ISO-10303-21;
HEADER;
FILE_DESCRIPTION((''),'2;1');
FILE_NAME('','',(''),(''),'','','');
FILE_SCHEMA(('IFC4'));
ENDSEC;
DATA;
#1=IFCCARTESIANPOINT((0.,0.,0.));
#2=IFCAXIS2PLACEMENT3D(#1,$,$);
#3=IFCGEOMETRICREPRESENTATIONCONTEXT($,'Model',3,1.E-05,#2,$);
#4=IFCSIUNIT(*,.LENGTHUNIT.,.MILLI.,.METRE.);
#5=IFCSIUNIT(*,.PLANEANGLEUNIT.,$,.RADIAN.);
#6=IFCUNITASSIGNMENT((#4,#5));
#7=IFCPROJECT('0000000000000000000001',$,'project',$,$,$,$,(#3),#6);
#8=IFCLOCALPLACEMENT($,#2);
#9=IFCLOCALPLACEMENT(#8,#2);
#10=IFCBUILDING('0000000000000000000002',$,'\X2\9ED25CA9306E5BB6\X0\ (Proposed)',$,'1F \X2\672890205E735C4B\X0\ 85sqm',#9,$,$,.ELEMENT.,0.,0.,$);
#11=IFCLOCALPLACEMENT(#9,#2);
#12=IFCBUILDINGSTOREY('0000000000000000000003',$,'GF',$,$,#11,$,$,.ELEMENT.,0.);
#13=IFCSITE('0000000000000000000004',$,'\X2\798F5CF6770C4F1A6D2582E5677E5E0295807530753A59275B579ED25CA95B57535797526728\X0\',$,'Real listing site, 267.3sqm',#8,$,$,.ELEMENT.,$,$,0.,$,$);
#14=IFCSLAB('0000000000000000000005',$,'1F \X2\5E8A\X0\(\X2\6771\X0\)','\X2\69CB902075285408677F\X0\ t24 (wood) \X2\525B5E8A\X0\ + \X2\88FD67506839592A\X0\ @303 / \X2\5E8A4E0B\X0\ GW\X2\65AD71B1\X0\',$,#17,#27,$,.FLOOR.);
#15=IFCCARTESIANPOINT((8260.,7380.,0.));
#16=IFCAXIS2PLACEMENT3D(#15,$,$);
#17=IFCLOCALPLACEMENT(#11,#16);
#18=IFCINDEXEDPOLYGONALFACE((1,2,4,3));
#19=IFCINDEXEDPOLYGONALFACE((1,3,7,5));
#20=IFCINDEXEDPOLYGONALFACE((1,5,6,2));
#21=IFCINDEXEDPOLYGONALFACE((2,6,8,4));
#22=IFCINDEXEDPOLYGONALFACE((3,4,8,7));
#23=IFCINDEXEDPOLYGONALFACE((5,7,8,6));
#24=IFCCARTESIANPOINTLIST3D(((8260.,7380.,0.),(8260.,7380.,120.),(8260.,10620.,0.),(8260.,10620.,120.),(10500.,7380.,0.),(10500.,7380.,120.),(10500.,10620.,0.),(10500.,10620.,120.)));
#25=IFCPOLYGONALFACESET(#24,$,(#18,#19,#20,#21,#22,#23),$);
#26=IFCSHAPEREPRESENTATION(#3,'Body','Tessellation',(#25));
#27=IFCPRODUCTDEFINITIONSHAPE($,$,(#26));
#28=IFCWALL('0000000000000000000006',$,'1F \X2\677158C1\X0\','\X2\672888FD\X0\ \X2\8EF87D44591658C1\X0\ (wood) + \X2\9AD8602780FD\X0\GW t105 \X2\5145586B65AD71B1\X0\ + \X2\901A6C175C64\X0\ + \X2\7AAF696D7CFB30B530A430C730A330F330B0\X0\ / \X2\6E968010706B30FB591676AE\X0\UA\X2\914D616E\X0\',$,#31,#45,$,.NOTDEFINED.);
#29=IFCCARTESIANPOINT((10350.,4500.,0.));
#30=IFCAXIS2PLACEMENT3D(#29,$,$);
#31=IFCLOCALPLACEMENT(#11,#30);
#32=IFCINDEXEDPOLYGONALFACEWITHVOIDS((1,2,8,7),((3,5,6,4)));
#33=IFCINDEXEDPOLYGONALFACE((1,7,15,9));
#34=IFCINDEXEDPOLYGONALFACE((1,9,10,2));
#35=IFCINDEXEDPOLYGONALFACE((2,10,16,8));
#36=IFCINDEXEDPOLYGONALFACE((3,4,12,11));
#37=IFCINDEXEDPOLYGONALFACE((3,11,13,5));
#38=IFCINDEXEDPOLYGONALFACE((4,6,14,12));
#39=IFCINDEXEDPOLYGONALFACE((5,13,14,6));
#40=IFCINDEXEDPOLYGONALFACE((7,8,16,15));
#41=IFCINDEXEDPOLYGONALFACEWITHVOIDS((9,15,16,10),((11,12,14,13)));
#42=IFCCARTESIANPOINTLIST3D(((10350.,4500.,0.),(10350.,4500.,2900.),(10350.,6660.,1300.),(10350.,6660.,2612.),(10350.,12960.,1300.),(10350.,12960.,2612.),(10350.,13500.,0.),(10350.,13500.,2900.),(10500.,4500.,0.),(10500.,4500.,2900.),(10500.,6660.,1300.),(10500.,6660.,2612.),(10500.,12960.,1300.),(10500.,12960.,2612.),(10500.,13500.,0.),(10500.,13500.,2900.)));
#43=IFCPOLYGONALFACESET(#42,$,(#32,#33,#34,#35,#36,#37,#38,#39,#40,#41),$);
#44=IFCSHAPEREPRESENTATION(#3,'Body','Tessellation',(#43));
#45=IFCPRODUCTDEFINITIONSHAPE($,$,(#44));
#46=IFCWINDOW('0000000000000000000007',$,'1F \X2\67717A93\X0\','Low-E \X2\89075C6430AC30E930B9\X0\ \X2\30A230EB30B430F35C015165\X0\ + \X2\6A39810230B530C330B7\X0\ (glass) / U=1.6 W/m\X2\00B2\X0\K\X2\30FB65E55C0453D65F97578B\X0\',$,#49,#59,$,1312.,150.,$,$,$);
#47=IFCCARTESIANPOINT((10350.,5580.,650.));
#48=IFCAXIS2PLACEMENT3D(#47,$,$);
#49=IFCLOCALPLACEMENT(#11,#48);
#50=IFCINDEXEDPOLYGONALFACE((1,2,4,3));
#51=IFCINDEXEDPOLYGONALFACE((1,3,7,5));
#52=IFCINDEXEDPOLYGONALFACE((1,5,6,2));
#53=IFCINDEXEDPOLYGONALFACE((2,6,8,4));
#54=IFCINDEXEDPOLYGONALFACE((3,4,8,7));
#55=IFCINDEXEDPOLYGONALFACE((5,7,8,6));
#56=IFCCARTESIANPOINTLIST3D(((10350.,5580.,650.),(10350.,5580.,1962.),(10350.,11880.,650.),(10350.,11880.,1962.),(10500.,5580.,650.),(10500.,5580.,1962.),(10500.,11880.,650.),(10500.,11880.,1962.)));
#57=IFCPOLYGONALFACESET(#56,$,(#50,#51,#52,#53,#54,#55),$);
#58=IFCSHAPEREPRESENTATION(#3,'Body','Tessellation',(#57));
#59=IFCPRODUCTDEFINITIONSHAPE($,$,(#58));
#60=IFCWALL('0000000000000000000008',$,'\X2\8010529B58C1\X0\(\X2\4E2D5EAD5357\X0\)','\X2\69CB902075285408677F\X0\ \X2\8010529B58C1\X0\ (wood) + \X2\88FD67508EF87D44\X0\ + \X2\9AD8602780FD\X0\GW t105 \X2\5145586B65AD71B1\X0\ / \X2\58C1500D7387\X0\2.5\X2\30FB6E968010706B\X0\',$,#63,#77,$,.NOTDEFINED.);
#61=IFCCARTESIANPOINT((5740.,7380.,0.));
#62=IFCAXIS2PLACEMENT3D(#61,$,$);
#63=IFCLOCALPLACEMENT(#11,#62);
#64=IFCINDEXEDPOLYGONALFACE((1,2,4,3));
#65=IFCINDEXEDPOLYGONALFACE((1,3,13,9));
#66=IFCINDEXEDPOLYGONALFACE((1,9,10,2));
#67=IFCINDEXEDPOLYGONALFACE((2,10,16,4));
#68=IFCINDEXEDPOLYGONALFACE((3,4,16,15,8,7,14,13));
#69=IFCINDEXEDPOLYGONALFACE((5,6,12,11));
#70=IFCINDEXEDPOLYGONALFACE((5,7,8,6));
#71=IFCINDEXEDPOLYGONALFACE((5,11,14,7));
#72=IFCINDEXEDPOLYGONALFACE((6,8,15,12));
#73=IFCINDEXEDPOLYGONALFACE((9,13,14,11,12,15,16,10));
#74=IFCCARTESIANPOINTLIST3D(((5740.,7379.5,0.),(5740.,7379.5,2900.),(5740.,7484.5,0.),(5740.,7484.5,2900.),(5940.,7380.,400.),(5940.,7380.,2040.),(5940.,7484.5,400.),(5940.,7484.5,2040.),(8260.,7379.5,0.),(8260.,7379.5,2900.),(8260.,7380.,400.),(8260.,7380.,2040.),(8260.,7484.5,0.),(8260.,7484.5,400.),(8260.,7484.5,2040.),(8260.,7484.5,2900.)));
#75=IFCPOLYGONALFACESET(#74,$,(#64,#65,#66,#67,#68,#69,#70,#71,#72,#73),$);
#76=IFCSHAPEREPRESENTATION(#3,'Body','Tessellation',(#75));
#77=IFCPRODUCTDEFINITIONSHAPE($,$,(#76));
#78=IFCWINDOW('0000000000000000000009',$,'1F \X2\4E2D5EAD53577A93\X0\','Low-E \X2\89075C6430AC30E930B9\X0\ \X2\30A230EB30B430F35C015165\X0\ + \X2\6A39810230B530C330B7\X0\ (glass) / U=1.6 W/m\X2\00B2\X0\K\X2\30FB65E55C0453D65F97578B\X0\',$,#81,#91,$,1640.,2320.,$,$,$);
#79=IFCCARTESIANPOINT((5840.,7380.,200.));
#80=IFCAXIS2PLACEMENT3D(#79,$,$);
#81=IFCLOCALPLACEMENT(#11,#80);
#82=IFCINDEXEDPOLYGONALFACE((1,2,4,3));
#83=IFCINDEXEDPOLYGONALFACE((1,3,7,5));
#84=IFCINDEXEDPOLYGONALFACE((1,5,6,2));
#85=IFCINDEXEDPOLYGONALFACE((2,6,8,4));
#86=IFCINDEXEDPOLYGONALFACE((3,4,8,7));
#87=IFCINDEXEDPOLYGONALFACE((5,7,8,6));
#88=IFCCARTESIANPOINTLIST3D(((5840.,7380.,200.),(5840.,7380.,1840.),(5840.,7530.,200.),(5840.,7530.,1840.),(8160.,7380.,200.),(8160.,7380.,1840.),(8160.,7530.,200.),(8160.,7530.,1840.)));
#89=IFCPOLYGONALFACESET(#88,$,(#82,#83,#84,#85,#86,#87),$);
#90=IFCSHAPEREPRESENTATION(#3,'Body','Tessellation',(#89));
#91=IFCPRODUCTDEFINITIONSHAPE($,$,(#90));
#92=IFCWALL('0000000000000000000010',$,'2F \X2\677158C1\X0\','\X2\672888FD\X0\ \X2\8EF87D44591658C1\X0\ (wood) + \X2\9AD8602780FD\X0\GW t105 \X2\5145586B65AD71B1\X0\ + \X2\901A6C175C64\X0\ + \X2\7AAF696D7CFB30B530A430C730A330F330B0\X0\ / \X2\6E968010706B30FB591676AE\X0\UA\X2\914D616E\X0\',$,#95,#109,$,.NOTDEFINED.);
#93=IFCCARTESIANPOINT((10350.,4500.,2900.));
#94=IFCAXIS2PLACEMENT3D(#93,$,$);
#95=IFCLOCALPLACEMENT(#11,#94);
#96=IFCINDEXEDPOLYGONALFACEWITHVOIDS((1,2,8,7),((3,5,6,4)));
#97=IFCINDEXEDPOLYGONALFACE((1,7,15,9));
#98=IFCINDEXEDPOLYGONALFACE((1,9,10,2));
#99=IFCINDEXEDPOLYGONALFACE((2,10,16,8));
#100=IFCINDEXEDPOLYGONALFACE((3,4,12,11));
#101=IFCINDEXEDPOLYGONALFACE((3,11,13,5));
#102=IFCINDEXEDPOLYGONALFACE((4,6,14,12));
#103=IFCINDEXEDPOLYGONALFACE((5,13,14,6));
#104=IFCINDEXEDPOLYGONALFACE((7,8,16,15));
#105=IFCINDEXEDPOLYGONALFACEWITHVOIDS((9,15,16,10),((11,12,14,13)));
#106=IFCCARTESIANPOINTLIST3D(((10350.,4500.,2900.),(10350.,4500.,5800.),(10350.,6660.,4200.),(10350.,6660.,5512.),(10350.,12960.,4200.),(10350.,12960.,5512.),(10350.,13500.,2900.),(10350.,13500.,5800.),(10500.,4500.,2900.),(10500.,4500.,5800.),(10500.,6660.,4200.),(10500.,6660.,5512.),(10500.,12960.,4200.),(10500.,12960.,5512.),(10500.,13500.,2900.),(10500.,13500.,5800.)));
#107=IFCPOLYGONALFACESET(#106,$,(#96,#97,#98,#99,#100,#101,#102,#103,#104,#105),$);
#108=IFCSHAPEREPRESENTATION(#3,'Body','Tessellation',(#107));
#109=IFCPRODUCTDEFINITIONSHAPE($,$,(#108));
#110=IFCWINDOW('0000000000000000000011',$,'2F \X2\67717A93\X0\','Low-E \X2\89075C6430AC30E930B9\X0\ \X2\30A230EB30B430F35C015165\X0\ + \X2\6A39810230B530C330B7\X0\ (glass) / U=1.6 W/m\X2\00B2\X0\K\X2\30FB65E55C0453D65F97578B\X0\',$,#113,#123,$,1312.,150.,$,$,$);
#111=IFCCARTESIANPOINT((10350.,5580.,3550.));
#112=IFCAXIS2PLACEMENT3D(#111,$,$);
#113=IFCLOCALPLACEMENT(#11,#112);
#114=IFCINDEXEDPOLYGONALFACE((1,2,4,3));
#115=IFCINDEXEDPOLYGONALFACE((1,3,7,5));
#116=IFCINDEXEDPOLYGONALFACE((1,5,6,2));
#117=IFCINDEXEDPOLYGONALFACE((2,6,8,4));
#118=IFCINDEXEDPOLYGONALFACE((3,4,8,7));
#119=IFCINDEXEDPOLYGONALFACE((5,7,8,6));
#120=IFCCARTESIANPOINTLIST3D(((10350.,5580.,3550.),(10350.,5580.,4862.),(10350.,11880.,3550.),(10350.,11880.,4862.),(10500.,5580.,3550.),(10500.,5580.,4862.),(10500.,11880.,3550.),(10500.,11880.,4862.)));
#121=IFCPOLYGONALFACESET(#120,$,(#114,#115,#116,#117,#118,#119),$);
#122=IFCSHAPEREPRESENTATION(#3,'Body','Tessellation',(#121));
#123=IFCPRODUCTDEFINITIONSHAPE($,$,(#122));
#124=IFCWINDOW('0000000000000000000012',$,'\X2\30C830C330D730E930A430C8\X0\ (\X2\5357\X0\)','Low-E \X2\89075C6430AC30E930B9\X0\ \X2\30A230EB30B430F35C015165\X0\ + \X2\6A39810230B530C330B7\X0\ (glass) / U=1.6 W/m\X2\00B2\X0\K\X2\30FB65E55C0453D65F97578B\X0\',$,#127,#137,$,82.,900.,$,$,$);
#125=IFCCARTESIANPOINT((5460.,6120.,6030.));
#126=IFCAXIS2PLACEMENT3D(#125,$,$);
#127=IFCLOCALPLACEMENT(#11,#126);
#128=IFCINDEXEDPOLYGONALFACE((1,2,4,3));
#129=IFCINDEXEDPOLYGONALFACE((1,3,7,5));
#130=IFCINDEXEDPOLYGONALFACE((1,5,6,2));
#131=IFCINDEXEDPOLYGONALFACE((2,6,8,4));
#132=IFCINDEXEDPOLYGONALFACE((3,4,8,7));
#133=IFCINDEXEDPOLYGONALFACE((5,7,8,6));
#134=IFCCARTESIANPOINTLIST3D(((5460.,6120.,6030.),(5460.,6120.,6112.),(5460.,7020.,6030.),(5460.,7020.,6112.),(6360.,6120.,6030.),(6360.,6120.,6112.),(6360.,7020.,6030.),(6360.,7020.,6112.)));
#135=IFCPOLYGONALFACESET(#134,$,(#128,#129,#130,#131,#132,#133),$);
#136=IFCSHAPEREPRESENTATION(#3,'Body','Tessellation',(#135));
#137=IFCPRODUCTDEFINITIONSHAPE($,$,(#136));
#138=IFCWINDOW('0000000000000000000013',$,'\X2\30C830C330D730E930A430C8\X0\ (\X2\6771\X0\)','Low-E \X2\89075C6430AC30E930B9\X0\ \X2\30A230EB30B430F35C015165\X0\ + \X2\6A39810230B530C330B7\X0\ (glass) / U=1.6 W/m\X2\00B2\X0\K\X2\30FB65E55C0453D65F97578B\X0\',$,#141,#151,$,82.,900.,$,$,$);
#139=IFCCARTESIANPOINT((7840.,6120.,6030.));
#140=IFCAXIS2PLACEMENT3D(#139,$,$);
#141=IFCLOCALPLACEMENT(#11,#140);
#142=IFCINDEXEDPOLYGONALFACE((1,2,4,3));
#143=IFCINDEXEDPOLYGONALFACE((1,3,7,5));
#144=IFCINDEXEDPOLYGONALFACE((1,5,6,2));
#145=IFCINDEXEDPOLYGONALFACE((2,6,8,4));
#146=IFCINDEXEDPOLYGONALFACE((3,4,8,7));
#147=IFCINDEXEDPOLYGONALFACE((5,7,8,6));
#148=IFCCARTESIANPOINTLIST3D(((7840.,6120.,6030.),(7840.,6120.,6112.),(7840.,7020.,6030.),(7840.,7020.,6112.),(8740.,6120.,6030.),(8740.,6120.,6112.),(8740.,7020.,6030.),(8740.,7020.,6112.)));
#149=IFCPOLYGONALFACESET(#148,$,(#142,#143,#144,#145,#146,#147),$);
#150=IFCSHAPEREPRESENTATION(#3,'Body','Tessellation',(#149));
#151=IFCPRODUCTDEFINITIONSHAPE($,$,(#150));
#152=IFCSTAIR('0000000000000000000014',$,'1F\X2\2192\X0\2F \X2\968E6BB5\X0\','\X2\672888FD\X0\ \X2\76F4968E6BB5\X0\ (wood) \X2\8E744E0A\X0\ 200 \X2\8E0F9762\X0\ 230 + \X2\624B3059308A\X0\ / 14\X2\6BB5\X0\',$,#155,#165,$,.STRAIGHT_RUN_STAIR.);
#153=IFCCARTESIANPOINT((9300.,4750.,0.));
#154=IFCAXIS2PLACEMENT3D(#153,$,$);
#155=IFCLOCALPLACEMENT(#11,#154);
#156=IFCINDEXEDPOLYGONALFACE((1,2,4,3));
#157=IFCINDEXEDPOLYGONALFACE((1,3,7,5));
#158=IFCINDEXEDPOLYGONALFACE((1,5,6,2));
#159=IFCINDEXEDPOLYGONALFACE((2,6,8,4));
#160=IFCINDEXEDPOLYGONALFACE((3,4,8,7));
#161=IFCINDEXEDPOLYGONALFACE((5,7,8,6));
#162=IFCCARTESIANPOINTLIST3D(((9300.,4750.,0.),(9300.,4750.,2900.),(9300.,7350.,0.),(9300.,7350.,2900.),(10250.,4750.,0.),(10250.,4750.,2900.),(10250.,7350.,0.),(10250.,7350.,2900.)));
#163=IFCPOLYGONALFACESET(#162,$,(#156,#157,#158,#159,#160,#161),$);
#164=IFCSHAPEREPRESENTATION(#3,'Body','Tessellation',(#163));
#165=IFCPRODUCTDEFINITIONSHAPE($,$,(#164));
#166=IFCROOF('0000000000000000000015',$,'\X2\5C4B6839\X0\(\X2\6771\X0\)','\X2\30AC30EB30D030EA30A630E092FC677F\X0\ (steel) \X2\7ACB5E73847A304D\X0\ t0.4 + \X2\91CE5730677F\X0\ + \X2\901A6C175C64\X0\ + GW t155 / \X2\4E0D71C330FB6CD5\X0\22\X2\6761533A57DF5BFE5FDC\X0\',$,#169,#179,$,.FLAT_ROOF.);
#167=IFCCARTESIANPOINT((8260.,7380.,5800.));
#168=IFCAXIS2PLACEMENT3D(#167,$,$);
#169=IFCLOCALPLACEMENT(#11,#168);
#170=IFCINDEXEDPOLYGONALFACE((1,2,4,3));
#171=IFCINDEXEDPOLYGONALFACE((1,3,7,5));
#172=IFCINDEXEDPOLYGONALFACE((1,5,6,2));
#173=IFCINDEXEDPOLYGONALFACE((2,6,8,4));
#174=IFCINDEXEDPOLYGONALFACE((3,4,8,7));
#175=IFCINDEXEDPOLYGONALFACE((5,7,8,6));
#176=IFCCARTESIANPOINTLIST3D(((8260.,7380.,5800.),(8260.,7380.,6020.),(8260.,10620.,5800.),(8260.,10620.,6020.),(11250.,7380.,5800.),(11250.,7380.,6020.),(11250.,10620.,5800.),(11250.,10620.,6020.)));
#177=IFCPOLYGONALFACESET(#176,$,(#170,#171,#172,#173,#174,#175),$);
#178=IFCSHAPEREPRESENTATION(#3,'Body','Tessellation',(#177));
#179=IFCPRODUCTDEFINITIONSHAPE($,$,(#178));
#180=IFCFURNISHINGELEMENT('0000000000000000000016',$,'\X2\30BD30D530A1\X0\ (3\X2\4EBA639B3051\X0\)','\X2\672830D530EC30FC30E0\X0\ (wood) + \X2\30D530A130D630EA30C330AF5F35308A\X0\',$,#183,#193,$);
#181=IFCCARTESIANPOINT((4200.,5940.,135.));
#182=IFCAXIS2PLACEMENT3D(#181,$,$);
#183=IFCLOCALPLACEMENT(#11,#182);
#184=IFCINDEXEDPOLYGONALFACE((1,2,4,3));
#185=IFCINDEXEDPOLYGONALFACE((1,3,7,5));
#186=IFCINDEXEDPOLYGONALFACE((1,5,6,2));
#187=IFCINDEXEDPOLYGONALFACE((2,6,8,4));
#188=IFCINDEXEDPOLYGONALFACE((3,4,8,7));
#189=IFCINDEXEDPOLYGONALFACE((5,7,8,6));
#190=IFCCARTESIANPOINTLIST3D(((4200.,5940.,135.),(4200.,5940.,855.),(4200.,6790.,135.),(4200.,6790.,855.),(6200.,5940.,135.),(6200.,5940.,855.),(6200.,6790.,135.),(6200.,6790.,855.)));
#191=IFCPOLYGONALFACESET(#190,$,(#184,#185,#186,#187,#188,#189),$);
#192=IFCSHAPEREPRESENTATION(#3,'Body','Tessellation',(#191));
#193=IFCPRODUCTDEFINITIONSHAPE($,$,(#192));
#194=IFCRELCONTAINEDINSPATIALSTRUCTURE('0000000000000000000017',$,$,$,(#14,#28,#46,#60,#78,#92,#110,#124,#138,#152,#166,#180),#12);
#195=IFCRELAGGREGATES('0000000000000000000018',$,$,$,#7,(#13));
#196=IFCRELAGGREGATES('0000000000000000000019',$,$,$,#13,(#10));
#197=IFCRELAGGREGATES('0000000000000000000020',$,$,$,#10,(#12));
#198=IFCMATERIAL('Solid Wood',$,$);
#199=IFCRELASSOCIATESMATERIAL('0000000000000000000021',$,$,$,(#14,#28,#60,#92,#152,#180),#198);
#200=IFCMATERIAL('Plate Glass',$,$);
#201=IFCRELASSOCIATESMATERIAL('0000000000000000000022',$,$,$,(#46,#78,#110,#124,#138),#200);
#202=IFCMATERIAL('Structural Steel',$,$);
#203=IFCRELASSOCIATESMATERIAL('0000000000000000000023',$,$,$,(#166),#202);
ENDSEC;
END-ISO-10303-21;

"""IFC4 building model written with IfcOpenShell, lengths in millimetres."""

from ifc_helpers import new_model, si_unit, frame, frame_2d, origin, place, context, project, spatial, rectangle, extrude, material, element, fill, save


model = new_model("IFC4")

# Units and contexts
model_context = context("Model", 3, precision=1e-05, world=origin())
ifc_project = project(units=[si_unit("LENGTHUNIT", "METRE", prefix="MILLI"), si_unit("PLANEANGLEUNIT", "RADIAN")], contexts=[model_context])

# Site, building, storey
site_placement = place(None, origin())
site = spatial("IfcSite", under=ifc_project, at=site_placement, Name="福島県会津若松市門田町大字黒岩字南青木", ObjectType="Real listing site, 267.3sqm", CompositionType="ELEMENT", RefElevation=0.0)
building_placement = place(site_placement, origin())
building = spatial("IfcBuilding", under=site, at=building_placement, Name="黒岩の家 (Proposed)", ObjectType="1F 木造平屋 85sqm", CompositionType="ELEMENT", ElevationOfRefHeight=0.0, ElevationOfTerrain=0.0)
storey_placement = place(building_placement, origin())
storey = spatial("IfcBuildingStorey", under=building, at=storey_placement, Name="GF", CompositionType="ELEMENT", Elevation=0.0)

# Slab
ifc_material_1 = material(Name="Solid Wood")
slab_placement = place(storey_placement, frame((8260.0, 7380.0, 0.0)))
element("IfcSlab", 1, at=slab_placement, inside=storey, material=ifc_material_1, Name="1F 床(東)", Description="構造用合板 t24 (wood) 剛床 + 製材根太 @303 / 床下 GW断熱", PredefinedType="FLOOR", context=model_context, shape_type="SweptSolid", body=[
    extrude(rectangle(XDim=2240.0, YDim=3240.0, at=frame_2d((1120.0, 1620.0))), frame((8260.0, 7380.0, 0.0)), (0.0, 0.0, 1.0), 120.0),
])

# Walls, openings, windows
wall_1_placement = place(storey_placement, frame((10350.0, 4500.0, 0.0)))
wall_1 = element("IfcWall", 2, at=wall_1_placement, inside=storey, material=ifc_material_1, Name="1F 東壁", Description="木製 軸組外壁 (wood) + 高性能GW t105 充填断熱 + 通気層 + 窯業系サイディング / 準耐火・外皮UA配慮", PredefinedType="NOTDEFINED", context=model_context, shape_type="SweptSolid", body=[
    extrude(rectangle(XDim=150.0, YDim=9000.0, at=frame_2d((75.0, 4500.0))), frame((10350.0, 4500.0, 0.0)), (0.0, 0.0, 1.0), 2900.0),
])
opening_1_placement = place(storey_placement, frame((10350.0, 5580.0, 650.0)))
opening_1 = element("IfcOpeningElement", 3, at=opening_1_placement, cuts=wall_1, PredefinedType="NOTDEFINED", context=model_context, shape_type="SweptSolid", body=[
    extrude(rectangle(XDim=150.0, YDim=6300.0, at=frame_2d((75.0, 3150.0))), frame((10350.0, 5580.0, 650.0)), (0.0, 0.0, 1.0), 1312.0),
])
ifc_material_2 = material(Name="Plate Glass")
window_1_placement = place(storey_placement, frame((10350.0, 5580.0, 650.0)))
window_1 = element("IfcWindow", 4, at=window_1_placement, inside=storey, material=ifc_material_2, Name="1F 東窓", Description="Low-E 複層ガラス アルゴン封入 + 樹脂サッシ (glass) / U=1.6 W/m²K・日射取得型", OverallHeight=1312.0, OverallWidth=150.0, context=model_context, shape_type="SweptSolid", body=[
    extrude(rectangle(XDim=150.0, YDim=6300.0, at=frame_2d((75.0, 3150.0))), frame((10350.0, 5580.0, 650.0)), (0.0, 0.0, 1.0), 1312.0),
])
fill(opening_1, window_1)
wall_2_placement = place(storey_placement, frame((5740.0, 7380.0, 0.0)))
wall_2 = element("IfcWall", 5, at=wall_2_placement, inside=storey, material=ifc_material_1, Name="耐力壁(中庭南)", Description="構造用合板 耐力壁 (wood) + 製材軸組 + 高性能GW t105 充填断熱 / 壁倍率2.5・準耐火", PredefinedType="NOTDEFINED", context=model_context, shape_type="SweptSolid", body=[
    extrude(rectangle(XDim=2520.0, YDim=105.0, at=frame_2d((1260.0, 52.0))), frame((5740.0, 7380.0, 0.0)), (0.0, 0.0, 1.0), 2900.0),
])
opening_2_placement = place(storey_placement, frame((5840.0, 7380.0, 200.0)))
opening_2 = element("IfcOpeningElement", 6, at=opening_2_placement, cuts=wall_2, PredefinedType="NOTDEFINED", context=model_context, shape_type="SweptSolid", body=[
    extrude(rectangle(XDim=2320.0, YDim=150.0, at=frame_2d((1160.0, 75.0))), frame((5840.0, 7380.0, 200.0)), (0.0, 0.0, 1.0), 1640.0),
])
window_2_placement = place(storey_placement, frame((5840.0, 7380.0, 200.0)))
window_2 = element("IfcWindow", 7, at=window_2_placement, inside=storey, material=ifc_material_2, Name="1F 中庭南窓", Description="Low-E 複層ガラス アルゴン封入 + 樹脂サッシ (glass) / U=1.6 W/m²K・日射取得型", OverallHeight=1640.0, OverallWidth=2320.0, context=model_context, shape_type="SweptSolid", body=[
    extrude(rectangle(XDim=2320.0, YDim=150.0, at=frame_2d((1160.0, 75.0))), frame((5840.0, 7380.0, 200.0)), (0.0, 0.0, 1.0), 1640.0),
])
fill(opening_2, window_2)

# Wall, opening, window
wall_3_placement = place(storey_placement, frame((10350.0, 4500.0, 2900.0)))
wall_3 = element("IfcWall", 8, at=wall_3_placement, inside=storey, material=ifc_material_1, Name="2F 東壁", Description="木製 軸組外壁 (wood) + 高性能GW t105 充填断熱 + 通気層 + 窯業系サイディング / 準耐火・外皮UA配慮", PredefinedType="NOTDEFINED", context=model_context, shape_type="SweptSolid", body=[
    extrude(rectangle(XDim=150.0, YDim=9000.0, at=frame_2d((75.0, 4500.0))), frame((10350.0, 4500.0, 2900.0)), (0.0, 0.0, 1.0), 2900.0),
])
opening_3_placement = place(storey_placement, frame((10350.0, 5580.0, 3550.0)))
opening_3 = element("IfcOpeningElement", 9, at=opening_3_placement, cuts=wall_3, PredefinedType="NOTDEFINED", context=model_context, shape_type="SweptSolid", body=[
    extrude(rectangle(XDim=150.0, YDim=6300.0, at=frame_2d((75.0, 3150.0))), frame((10350.0, 5580.0, 3550.0)), (0.0, 0.0, 1.0), 1312.0),
])
window_3_placement = place(storey_placement, frame((10350.0, 5580.0, 3550.0)))
window_3 = element("IfcWindow", 10, at=window_3_placement, inside=storey, material=ifc_material_2, Name="2F 東窓", Description="Low-E 複層ガラス アルゴン封入 + 樹脂サッシ (glass) / U=1.6 W/m²K・日射取得型", OverallHeight=1312.0, OverallWidth=150.0, context=model_context, shape_type="SweptSolid", body=[
    extrude(rectangle(XDim=150.0, YDim=6300.0, at=frame_2d((75.0, 3150.0))), frame((10350.0, 5580.0, 3550.0)), (0.0, 0.0, 1.0), 1312.0),
])
fill(opening_3, window_3)

# Windows
window_4_placement = place(storey_placement, frame((5460.0, 6120.0, 6030.0)))
element("IfcWindow", 11, at=window_4_placement, inside=storey, material=ifc_material_2, Name="トップライト (南)", Description="Low-E 複層ガラス アルゴン封入 + 樹脂サッシ (glass) / U=1.6 W/m²K・日射取得型", OverallHeight=82.0, OverallWidth=900.0, context=model_context, shape_type="SweptSolid", body=[
    extrude(rectangle(XDim=900.0, YDim=900.0, at=frame_2d((450.0, 450.0))), frame((5460.0, 6120.0, 6030.0)), (0.0, 0.0, 1.0), 82.0),
])
window_5_placement = place(storey_placement, frame((7840.0, 6120.0, 6030.0)))
element("IfcWindow", 12, at=window_5_placement, inside=storey, material=ifc_material_2, Name="トップライト (東)", Description="Low-E 複層ガラス アルゴン封入 + 樹脂サッシ (glass) / U=1.6 W/m²K・日射取得型", OverallHeight=82.0, OverallWidth=900.0, context=model_context, shape_type="SweptSolid", body=[
    extrude(rectangle(XDim=900.0, YDim=900.0, at=frame_2d((450.0, 450.0))), frame((7840.0, 6120.0, 6030.0)), (0.0, 0.0, 1.0), 82.0),
])

# Stair
stair_placement = place(storey_placement, frame((9300.0, 4750.0, 0.0)))
element("IfcStair", 13, at=stair_placement, inside=storey, material=ifc_material_1, Name="1F→2F 階段", Description="木製 直階段 (wood) 蹴上 200 踏面 230 + 手すり / 14段", PredefinedType="STRAIGHT_RUN_STAIR", context=model_context, shape_type="SweptSolid", body=[
    extrude(rectangle(XDim=950.0, YDim=2600.0, at=frame_2d((475.0, 1300.0))), frame((9300.0, 4750.0, 0.0)), (0.0, 0.0, 1.0), 2900.0),
])

# Roof
ifc_material_3 = material(Name="Structural Steel")
roof_placement = place(storey_placement, frame((8260.0, 7380.0, 5800.0)))
element("IfcRoof", 14, at=roof_placement, inside=storey, material=ifc_material_3, Name="屋根(東)", Description="ガルバリウム鋼板 (steel) 立平葺き t0.4 + 野地板 + 通気層 + GW t155 / 不燃・法22条区域対応", PredefinedType="FLAT_ROOF", context=model_context, shape_type="SweptSolid", body=[
    extrude(rectangle(XDim=2990.0, YDim=3240.0, at=frame_2d((1495.0, 1620.0))), frame((8260.0, 7380.0, 5800.0)), (0.0, 0.0, 1.0), 220.0),
])

# Furnishing element
furnishing_1_placement = place(storey_placement, frame((4200.0, 5940.0, 135.0)))
element("IfcFurnishingElement", 15, at=furnishing_1_placement, inside=storey, material=ifc_material_1, Name="ソファ (3人掛け)", Description="木フレーム (wood) + ファブリック張り", context=model_context, shape_type="SweptSolid", body=[
    extrude(rectangle(XDim=2000.0, YDim=850.0, at=frame_2d((1000.0, 425.0))), frame((4200.0, 5940.0, 135.0)), (0.0, 0.0, 1.0), 720.0),
])

save(model, "model.ifc")
